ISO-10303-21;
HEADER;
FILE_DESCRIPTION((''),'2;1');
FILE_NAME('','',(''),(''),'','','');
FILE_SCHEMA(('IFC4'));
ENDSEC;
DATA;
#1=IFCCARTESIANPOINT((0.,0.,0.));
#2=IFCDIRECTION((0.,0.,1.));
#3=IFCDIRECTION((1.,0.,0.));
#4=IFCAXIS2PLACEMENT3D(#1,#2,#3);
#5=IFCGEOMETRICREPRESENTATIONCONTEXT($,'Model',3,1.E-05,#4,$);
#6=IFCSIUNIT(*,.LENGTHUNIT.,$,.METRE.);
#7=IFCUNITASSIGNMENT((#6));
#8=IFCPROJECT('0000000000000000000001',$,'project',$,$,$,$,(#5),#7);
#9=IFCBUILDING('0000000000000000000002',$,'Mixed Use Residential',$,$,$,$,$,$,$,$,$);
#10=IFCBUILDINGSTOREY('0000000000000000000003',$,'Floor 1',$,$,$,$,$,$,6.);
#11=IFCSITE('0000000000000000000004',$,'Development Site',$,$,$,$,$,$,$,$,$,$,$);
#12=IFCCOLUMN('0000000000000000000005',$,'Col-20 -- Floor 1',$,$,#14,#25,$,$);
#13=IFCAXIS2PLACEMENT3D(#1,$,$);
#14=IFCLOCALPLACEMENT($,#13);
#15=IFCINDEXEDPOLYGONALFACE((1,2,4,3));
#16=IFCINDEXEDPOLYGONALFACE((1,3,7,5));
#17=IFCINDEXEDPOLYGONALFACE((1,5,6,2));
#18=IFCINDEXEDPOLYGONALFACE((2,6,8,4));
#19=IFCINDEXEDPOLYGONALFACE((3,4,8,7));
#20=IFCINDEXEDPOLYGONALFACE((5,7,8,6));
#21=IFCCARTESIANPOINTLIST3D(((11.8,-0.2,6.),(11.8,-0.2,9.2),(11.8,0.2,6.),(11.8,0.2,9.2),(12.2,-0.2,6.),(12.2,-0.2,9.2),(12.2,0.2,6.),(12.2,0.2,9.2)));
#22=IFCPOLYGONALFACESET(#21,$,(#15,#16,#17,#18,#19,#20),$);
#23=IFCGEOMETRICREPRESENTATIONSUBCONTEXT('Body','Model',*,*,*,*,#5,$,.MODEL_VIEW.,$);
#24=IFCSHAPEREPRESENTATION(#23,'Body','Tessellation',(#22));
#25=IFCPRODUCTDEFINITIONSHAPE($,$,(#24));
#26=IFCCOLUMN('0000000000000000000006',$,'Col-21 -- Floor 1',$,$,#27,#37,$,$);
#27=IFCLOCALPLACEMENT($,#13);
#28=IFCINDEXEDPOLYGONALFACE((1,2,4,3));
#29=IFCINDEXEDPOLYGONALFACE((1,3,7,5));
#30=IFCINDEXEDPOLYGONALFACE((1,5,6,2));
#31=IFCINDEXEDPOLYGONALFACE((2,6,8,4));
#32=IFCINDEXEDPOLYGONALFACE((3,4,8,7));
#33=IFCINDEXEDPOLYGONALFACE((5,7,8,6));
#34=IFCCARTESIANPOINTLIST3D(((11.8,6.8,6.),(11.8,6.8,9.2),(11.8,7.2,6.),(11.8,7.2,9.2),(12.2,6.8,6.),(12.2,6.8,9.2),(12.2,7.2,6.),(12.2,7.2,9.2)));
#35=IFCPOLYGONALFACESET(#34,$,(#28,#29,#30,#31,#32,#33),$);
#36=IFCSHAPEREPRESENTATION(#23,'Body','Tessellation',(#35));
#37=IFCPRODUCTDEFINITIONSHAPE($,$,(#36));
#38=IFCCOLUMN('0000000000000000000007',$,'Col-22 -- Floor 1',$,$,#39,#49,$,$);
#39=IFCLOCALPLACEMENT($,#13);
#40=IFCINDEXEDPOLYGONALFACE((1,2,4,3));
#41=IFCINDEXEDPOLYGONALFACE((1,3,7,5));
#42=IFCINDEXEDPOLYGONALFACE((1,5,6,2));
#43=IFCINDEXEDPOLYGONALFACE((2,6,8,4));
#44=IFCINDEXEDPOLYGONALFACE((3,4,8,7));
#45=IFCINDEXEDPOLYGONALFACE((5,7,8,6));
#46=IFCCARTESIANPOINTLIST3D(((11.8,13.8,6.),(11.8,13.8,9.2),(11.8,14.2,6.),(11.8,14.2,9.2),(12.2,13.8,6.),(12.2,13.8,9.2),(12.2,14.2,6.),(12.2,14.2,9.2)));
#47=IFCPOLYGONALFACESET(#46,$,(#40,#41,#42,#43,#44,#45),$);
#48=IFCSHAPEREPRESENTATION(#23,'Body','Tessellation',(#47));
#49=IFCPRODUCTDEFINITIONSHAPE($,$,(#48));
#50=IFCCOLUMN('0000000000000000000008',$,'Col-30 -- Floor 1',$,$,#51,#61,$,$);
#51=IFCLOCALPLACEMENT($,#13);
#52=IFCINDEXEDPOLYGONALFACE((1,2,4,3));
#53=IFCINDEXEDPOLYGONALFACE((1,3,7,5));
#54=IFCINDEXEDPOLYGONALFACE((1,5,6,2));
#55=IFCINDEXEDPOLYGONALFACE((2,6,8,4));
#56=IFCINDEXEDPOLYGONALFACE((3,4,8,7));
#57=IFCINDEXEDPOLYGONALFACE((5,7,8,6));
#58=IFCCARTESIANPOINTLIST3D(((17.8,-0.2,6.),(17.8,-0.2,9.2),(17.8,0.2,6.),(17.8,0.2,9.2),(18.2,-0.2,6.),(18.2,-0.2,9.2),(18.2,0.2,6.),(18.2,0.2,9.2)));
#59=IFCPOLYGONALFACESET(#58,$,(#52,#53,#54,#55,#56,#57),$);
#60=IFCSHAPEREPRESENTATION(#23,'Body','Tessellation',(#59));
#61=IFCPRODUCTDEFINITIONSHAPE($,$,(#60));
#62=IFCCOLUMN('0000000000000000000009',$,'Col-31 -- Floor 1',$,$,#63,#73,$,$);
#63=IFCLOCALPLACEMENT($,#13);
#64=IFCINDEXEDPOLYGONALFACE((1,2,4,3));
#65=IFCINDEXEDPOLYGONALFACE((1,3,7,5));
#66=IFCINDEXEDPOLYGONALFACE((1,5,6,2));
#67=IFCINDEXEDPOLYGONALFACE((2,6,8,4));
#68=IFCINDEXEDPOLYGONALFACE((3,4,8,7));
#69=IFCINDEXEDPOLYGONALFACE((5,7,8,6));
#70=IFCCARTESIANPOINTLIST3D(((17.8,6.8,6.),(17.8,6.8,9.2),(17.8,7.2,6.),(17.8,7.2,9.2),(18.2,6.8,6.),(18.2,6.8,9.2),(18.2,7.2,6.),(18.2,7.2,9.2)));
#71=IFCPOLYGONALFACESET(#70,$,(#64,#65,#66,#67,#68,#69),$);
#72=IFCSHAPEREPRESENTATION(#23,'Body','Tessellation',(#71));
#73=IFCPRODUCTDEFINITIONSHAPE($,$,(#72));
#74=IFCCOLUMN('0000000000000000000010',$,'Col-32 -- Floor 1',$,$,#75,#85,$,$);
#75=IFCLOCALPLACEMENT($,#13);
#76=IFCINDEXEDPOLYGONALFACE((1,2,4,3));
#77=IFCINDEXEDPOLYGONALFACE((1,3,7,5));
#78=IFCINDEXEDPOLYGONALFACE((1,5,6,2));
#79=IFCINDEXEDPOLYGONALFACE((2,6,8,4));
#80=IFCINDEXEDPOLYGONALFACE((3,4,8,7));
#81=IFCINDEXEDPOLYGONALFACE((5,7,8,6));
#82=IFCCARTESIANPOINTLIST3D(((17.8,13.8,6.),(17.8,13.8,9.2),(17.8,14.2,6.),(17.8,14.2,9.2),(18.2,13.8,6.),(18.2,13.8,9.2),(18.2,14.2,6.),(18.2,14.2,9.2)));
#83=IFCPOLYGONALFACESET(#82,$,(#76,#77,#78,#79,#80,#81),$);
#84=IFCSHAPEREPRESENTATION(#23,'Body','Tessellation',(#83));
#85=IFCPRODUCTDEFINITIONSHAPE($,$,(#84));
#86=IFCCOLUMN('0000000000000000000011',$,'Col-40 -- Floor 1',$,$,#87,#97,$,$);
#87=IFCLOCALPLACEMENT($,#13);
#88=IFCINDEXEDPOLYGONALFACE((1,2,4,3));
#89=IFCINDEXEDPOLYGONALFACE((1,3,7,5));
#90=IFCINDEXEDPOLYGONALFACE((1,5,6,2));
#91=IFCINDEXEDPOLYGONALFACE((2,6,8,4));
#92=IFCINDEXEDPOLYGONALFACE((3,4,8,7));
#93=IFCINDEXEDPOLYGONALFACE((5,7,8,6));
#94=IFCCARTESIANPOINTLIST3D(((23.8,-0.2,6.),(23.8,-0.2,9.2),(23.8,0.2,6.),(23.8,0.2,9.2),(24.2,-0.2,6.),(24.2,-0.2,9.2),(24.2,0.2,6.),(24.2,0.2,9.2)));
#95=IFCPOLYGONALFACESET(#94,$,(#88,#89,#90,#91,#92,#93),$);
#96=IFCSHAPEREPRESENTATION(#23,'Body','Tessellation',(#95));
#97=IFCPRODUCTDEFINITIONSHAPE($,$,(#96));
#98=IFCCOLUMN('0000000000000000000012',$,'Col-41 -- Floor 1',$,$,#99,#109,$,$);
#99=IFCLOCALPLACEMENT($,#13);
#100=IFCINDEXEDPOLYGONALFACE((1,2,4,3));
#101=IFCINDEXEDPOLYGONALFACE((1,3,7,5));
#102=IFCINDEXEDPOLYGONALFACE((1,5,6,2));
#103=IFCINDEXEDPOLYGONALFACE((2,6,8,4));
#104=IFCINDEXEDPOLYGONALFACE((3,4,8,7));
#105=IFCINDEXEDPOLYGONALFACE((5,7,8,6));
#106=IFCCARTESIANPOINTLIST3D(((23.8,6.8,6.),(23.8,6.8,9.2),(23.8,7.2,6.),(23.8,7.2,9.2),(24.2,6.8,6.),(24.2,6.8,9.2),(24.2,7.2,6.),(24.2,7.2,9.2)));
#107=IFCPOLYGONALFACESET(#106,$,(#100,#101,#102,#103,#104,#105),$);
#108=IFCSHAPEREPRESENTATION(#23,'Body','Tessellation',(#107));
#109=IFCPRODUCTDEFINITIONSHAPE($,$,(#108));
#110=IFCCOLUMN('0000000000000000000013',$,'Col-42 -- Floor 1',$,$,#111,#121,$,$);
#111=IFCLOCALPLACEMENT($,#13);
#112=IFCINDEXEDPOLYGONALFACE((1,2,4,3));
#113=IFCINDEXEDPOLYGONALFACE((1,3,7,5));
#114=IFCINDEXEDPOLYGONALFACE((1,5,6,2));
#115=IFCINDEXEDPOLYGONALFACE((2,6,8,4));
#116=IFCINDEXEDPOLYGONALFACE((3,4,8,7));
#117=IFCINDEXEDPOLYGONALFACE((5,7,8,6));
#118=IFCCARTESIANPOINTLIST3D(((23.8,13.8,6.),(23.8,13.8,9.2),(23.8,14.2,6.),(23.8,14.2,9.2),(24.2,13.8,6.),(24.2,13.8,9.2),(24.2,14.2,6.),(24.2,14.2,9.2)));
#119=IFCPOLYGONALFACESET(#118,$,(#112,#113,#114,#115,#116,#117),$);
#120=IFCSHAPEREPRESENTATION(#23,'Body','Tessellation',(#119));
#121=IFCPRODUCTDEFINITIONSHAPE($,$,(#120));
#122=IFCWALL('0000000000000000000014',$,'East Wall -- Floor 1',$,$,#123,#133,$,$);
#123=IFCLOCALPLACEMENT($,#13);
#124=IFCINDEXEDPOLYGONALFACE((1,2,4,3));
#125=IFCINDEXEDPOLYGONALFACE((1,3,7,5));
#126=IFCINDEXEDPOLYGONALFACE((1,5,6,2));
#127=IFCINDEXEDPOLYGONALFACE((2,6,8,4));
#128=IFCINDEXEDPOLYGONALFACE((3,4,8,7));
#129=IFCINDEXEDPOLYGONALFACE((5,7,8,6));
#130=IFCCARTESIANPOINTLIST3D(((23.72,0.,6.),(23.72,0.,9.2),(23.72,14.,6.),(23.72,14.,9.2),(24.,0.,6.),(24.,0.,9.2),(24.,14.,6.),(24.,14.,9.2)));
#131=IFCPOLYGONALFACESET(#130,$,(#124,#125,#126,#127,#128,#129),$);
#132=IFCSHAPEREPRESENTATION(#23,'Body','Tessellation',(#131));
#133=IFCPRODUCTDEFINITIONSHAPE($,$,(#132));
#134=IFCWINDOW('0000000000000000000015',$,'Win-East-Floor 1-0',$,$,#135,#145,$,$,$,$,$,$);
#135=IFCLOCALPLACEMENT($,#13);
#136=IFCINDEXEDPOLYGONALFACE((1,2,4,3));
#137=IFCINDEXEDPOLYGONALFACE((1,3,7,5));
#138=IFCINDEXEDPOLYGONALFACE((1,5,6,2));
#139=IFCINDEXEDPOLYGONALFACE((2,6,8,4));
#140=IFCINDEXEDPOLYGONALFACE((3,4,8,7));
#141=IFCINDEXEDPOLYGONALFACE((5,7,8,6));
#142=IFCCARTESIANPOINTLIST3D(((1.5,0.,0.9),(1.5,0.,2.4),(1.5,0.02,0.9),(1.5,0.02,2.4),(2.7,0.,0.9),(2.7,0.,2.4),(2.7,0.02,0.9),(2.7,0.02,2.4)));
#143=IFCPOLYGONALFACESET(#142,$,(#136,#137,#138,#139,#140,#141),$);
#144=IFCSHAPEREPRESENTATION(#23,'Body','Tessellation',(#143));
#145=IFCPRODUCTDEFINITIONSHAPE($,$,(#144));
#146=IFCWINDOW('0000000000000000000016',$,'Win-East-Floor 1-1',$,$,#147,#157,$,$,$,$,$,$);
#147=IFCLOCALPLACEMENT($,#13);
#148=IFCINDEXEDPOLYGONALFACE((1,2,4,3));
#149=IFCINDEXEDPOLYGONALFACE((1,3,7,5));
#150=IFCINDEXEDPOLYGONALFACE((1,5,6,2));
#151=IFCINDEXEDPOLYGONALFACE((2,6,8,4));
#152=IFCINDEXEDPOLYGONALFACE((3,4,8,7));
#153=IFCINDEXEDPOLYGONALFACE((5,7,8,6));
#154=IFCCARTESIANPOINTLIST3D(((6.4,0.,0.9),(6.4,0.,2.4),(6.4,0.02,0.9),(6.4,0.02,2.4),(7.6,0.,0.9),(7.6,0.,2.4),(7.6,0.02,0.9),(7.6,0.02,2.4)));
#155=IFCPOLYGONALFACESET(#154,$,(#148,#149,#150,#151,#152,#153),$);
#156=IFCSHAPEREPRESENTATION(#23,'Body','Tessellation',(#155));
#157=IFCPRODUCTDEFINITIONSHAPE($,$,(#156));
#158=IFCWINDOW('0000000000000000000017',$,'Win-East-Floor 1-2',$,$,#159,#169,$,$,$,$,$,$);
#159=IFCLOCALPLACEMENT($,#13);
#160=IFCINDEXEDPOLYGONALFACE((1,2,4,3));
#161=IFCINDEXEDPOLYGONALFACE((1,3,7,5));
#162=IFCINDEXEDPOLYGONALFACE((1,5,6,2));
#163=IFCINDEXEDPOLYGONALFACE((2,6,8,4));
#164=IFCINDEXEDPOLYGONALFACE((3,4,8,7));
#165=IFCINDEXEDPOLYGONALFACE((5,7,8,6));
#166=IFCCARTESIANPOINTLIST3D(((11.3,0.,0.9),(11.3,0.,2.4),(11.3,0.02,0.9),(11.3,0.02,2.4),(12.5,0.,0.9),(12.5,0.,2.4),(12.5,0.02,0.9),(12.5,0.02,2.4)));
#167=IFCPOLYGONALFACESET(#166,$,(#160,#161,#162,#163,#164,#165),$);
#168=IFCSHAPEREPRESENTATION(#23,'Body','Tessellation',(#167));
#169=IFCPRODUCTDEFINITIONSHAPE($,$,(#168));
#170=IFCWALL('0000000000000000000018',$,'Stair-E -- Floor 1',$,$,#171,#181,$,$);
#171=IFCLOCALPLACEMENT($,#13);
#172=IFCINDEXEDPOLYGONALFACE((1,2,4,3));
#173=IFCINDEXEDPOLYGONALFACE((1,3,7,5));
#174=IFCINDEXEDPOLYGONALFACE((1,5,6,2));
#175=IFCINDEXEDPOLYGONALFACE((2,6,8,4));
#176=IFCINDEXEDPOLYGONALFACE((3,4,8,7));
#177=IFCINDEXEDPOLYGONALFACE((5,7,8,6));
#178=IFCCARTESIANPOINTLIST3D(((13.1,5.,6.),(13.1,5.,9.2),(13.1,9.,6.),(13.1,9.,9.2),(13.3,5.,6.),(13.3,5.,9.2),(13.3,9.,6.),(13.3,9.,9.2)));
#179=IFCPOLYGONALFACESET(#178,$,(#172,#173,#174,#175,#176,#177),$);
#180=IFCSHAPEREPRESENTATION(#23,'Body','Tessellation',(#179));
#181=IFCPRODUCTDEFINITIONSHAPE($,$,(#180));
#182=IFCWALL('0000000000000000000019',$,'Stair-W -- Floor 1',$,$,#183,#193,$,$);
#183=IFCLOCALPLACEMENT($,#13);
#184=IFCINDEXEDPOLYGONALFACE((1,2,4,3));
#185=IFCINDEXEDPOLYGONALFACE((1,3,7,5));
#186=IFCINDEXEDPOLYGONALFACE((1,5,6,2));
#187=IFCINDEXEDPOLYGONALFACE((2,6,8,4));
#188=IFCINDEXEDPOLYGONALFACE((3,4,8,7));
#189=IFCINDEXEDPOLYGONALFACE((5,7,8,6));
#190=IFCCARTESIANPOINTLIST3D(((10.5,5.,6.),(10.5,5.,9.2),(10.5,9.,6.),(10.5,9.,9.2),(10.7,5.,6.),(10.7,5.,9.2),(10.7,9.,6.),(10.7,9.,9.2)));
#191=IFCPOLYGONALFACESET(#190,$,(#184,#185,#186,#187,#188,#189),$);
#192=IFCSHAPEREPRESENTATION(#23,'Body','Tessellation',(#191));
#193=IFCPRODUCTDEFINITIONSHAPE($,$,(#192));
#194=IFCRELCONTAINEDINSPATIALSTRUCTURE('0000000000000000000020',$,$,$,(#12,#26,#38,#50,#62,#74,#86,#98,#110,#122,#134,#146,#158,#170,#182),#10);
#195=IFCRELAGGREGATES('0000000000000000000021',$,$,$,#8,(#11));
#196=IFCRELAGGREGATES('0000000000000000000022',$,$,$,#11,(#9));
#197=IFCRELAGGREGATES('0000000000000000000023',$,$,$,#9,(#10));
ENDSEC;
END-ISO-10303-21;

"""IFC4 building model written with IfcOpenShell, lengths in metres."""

from ifc_helpers import new_model, si_unit, frame, origin_with_axes, place, context, subcontext, project, spatial, indexed_curve, rectangle, outline, extrude, element, fill, save


model = new_model("IFC4")

# Units and contexts
model_context = context("Model", 3, precision=1e-05, world=origin_with_axes())
body_context = subcontext(model_context, "Body", "Model", "MODEL_VIEW")
ifc_project = project(units=[si_unit("LENGTHUNIT", "METRE")], contexts=[model_context])

# Site, building, storey
site = spatial("IfcSite", under=ifc_project, Name="Development Site")
building = spatial("IfcBuilding", under=site, Name="Mixed Use Residential")
storey = spatial("IfcBuildingStorey", under=building, Name="Floor 1", Elevation=6.0)

# Columns
for number, where, z_axis, x_axis, name in (
    (1, (12.0, 0.0, 6.0), (0.0, 0.0, 1.0), (1.0, 0.0, 0.0), "Col-20 -- Floor 1"),
    (2, (12.0, 7.0, 6.0), (0.0, 0.0, 1.0), (1.0, 0.0, 0.0), "Col-21 -- Floor 1"),
    (3, (12.0, 14.0, 6.0), (0.0, 0.0, 1.0), (1.0, 0.0, 0.0), "Col-22 -- Floor 1"),
    (4, (18.0, 0.0, 6.0), (0.0, 0.0, 1.0), (1.0, 0.0, 0.0), "Col-30 -- Floor 1"),
    (5, (18.0, 7.0, 6.0), (0.0, 0.0, 1.0), (1.0, 0.0, 0.0), "Col-31 -- Floor 1"),
    (6, (18.0, 14.0, 6.0), (0.0, 0.0, 1.0), (1.0, 0.0, 0.0), "Col-32 -- Floor 1"),
    (7, (24.0, 0.0, 6.0), (0.0, 0.0, 1.0), (1.0, 0.0, 0.0), "Col-40 -- Floor 1"),
    (8, (24.0, 7.0, 6.0), (0.0, 0.0, 1.0), (1.0, 0.0, 0.0), "Col-41 -- Floor 1"),
    (9, (24.0, 14.0, 6.0), (0.0, 0.0, 1.0), (1.0, 0.0, 0.0), "Col-42 -- Floor 1"),
):
    element("IfcColumn", number, at=place(None, frame(where, z_axis=z_axis, x_axis=x_axis)), inside=storey, Name=name, context=body_context, shape_type="SweptSolid", body=[
        extrude(rectangle(XDim=0.4, YDim=0.4), origin_with_axes(), (0.0, 0.0, 1.0), 3.2),
    ])

# Wall, openings, windows
wall_placement = place(None, frame((24.0, 0.0, 6.0), z_axis=(0.0, 0.0, 1.0), x_axis=(0.0, 1.0, 0.0)))
wall = element("IfcWall", 10, at=wall_placement, inside=storey, Name="East Wall -- Floor 1", context=body_context, shape_type="SweptSolid", body=[
    extrude(outline(indexed_curve([(0.0, 0.0), (0.0, 0.28), (14.0, 0.28), (14.0, 0.0), (0.0, 0.0)], self_intersect=False)), origin_with_axes(), (0.0, 0.0, 1.0), 3.2),
])
opening_1_placement = place(wall_placement, frame((0.0, 22.5, -5.1), z_axis=(0.0, 0.0, 1.0), x_axis=(0.0, -1.0, 0.0)))
opening_1 = element("IfcOpeningElement", 11, at=opening_1_placement, cuts=wall, context=body_context, shape_type="SweptSolid", body=[
    extrude(outline(indexed_curve([(0.0, 0.0), (0.0, 0.28), (1.2, 0.28), (1.2, 0.0), (0.0, 0.0)], self_intersect=False)), origin_with_axes(), (0.0, 0.0, 1.0), 1.5),
])
opening_2_placement = place(wall_placement, frame((0.0, 17.6, -5.1), z_axis=(0.0, 0.0, 1.0), x_axis=(0.0, -1.0, 0.0)))
opening_2 = element("IfcOpeningElement", 12, at=opening_2_placement, cuts=wall, context=body_context, shape_type="SweptSolid", body=[
    extrude(outline(indexed_curve([(0.0, 0.0), (0.0, 0.28), (1.2, 0.28), (1.2, 0.0), (0.0, 0.0)], self_intersect=False)), origin_with_axes(), (0.0, 0.0, 1.0), 1.5),
])
opening_3_placement = place(wall_placement, frame((0.0, 12.7, -5.1), z_axis=(0.0, 0.0, 1.0), x_axis=(0.0, -1.0, 0.0)))
opening_3 = element("IfcOpeningElement", 13, at=opening_3_placement, cuts=wall, context=body_context, shape_type="SweptSolid", body=[
    extrude(outline(indexed_curve([(0.0, 0.0), (0.0, 0.28), (1.2, 0.28), (1.2, 0.0), (0.0, 0.0)], self_intersect=False)), origin_with_axes(), (0.0, 0.0, 1.0), 1.5),
])
window_1_placement = place(None, frame((1.5, 0.0, 0.9), z_axis=(0.0, 0.0, 1.0), x_axis=(1.0, 0.0, 0.0)))
window_1 = element("IfcWindow", 14, at=window_1_placement, inside=storey, Name="Win-East-Floor 1-0", context=body_context, shape_type="SweptSolid", body=[
    extrude(outline(indexed_curve([(0.0, 0.0), (0.0, 0.02), (1.2, 0.02), (1.2, 0.0), (0.0, 0.0)], self_intersect=False)), origin_with_axes(), (0.0, 0.0, 1.0), 1.5),
])
fill(opening_1, window_1)
window_2_placement = place(None, frame((6.4, 0.0, 0.9), z_axis=(0.0, 0.0, 1.0), x_axis=(1.0, 0.0, 0.0)))
window_2 = element("IfcWindow", 15, at=window_2_placement, inside=storey, Name="Win-East-Floor 1-1", context=body_context, shape_type="SweptSolid", body=[
    extrude(outline(indexed_curve([(0.0, 0.0), (0.0, 0.02), (1.2, 0.02), (1.2, 0.0), (0.0, 0.0)], self_intersect=False)), origin_with_axes(), (0.0, 0.0, 1.0), 1.5),
])
fill(opening_2, window_2)
window_3_placement = place(None, frame((11.3, 0.0, 0.9), z_axis=(0.0, 0.0, 1.0), x_axis=(1.0, 0.0, 0.0)))
window_3 = element("IfcWindow", 16, at=window_3_placement, inside=storey, Name="Win-East-Floor 1-2", context=body_context, shape_type="SweptSolid", body=[
    extrude(outline(indexed_curve([(0.0, 0.0), (0.0, 0.02), (1.2, 0.02), (1.2, 0.0), (0.0, 0.0)], self_intersect=False)), origin_with_axes(), (0.0, 0.0, 1.0), 1.5),
])
fill(opening_3, window_3)

# Walls
for number, where, z_axis, x_axis, name in (
    (17, (13.3, 5.0, 6.0), (0.0, 0.0, 1.0), (0.0, 1.0, 0.0), "Stair-E -- Floor 1"),
    (18, (10.7, 5.0, 6.0), (0.0, 0.0, 1.0), (0.0, 1.0, 0.0), "Stair-W -- Floor 1"),
):
    element("IfcWall", number, at=place(None, frame(where, z_axis=z_axis, x_axis=x_axis)), inside=storey, Name=name, context=body_context, shape_type="SweptSolid", body=[
        extrude(outline(indexed_curve([(0.0, 0.0), (0.0, 0.2), (4.0, 0.2), (4.0, 0.0), (0.0, 0.0)], self_intersect=False)), origin_with_axes(), (0.0, 0.0, 1.0), 3.2),
    ])

save(model, "model.ifc")
